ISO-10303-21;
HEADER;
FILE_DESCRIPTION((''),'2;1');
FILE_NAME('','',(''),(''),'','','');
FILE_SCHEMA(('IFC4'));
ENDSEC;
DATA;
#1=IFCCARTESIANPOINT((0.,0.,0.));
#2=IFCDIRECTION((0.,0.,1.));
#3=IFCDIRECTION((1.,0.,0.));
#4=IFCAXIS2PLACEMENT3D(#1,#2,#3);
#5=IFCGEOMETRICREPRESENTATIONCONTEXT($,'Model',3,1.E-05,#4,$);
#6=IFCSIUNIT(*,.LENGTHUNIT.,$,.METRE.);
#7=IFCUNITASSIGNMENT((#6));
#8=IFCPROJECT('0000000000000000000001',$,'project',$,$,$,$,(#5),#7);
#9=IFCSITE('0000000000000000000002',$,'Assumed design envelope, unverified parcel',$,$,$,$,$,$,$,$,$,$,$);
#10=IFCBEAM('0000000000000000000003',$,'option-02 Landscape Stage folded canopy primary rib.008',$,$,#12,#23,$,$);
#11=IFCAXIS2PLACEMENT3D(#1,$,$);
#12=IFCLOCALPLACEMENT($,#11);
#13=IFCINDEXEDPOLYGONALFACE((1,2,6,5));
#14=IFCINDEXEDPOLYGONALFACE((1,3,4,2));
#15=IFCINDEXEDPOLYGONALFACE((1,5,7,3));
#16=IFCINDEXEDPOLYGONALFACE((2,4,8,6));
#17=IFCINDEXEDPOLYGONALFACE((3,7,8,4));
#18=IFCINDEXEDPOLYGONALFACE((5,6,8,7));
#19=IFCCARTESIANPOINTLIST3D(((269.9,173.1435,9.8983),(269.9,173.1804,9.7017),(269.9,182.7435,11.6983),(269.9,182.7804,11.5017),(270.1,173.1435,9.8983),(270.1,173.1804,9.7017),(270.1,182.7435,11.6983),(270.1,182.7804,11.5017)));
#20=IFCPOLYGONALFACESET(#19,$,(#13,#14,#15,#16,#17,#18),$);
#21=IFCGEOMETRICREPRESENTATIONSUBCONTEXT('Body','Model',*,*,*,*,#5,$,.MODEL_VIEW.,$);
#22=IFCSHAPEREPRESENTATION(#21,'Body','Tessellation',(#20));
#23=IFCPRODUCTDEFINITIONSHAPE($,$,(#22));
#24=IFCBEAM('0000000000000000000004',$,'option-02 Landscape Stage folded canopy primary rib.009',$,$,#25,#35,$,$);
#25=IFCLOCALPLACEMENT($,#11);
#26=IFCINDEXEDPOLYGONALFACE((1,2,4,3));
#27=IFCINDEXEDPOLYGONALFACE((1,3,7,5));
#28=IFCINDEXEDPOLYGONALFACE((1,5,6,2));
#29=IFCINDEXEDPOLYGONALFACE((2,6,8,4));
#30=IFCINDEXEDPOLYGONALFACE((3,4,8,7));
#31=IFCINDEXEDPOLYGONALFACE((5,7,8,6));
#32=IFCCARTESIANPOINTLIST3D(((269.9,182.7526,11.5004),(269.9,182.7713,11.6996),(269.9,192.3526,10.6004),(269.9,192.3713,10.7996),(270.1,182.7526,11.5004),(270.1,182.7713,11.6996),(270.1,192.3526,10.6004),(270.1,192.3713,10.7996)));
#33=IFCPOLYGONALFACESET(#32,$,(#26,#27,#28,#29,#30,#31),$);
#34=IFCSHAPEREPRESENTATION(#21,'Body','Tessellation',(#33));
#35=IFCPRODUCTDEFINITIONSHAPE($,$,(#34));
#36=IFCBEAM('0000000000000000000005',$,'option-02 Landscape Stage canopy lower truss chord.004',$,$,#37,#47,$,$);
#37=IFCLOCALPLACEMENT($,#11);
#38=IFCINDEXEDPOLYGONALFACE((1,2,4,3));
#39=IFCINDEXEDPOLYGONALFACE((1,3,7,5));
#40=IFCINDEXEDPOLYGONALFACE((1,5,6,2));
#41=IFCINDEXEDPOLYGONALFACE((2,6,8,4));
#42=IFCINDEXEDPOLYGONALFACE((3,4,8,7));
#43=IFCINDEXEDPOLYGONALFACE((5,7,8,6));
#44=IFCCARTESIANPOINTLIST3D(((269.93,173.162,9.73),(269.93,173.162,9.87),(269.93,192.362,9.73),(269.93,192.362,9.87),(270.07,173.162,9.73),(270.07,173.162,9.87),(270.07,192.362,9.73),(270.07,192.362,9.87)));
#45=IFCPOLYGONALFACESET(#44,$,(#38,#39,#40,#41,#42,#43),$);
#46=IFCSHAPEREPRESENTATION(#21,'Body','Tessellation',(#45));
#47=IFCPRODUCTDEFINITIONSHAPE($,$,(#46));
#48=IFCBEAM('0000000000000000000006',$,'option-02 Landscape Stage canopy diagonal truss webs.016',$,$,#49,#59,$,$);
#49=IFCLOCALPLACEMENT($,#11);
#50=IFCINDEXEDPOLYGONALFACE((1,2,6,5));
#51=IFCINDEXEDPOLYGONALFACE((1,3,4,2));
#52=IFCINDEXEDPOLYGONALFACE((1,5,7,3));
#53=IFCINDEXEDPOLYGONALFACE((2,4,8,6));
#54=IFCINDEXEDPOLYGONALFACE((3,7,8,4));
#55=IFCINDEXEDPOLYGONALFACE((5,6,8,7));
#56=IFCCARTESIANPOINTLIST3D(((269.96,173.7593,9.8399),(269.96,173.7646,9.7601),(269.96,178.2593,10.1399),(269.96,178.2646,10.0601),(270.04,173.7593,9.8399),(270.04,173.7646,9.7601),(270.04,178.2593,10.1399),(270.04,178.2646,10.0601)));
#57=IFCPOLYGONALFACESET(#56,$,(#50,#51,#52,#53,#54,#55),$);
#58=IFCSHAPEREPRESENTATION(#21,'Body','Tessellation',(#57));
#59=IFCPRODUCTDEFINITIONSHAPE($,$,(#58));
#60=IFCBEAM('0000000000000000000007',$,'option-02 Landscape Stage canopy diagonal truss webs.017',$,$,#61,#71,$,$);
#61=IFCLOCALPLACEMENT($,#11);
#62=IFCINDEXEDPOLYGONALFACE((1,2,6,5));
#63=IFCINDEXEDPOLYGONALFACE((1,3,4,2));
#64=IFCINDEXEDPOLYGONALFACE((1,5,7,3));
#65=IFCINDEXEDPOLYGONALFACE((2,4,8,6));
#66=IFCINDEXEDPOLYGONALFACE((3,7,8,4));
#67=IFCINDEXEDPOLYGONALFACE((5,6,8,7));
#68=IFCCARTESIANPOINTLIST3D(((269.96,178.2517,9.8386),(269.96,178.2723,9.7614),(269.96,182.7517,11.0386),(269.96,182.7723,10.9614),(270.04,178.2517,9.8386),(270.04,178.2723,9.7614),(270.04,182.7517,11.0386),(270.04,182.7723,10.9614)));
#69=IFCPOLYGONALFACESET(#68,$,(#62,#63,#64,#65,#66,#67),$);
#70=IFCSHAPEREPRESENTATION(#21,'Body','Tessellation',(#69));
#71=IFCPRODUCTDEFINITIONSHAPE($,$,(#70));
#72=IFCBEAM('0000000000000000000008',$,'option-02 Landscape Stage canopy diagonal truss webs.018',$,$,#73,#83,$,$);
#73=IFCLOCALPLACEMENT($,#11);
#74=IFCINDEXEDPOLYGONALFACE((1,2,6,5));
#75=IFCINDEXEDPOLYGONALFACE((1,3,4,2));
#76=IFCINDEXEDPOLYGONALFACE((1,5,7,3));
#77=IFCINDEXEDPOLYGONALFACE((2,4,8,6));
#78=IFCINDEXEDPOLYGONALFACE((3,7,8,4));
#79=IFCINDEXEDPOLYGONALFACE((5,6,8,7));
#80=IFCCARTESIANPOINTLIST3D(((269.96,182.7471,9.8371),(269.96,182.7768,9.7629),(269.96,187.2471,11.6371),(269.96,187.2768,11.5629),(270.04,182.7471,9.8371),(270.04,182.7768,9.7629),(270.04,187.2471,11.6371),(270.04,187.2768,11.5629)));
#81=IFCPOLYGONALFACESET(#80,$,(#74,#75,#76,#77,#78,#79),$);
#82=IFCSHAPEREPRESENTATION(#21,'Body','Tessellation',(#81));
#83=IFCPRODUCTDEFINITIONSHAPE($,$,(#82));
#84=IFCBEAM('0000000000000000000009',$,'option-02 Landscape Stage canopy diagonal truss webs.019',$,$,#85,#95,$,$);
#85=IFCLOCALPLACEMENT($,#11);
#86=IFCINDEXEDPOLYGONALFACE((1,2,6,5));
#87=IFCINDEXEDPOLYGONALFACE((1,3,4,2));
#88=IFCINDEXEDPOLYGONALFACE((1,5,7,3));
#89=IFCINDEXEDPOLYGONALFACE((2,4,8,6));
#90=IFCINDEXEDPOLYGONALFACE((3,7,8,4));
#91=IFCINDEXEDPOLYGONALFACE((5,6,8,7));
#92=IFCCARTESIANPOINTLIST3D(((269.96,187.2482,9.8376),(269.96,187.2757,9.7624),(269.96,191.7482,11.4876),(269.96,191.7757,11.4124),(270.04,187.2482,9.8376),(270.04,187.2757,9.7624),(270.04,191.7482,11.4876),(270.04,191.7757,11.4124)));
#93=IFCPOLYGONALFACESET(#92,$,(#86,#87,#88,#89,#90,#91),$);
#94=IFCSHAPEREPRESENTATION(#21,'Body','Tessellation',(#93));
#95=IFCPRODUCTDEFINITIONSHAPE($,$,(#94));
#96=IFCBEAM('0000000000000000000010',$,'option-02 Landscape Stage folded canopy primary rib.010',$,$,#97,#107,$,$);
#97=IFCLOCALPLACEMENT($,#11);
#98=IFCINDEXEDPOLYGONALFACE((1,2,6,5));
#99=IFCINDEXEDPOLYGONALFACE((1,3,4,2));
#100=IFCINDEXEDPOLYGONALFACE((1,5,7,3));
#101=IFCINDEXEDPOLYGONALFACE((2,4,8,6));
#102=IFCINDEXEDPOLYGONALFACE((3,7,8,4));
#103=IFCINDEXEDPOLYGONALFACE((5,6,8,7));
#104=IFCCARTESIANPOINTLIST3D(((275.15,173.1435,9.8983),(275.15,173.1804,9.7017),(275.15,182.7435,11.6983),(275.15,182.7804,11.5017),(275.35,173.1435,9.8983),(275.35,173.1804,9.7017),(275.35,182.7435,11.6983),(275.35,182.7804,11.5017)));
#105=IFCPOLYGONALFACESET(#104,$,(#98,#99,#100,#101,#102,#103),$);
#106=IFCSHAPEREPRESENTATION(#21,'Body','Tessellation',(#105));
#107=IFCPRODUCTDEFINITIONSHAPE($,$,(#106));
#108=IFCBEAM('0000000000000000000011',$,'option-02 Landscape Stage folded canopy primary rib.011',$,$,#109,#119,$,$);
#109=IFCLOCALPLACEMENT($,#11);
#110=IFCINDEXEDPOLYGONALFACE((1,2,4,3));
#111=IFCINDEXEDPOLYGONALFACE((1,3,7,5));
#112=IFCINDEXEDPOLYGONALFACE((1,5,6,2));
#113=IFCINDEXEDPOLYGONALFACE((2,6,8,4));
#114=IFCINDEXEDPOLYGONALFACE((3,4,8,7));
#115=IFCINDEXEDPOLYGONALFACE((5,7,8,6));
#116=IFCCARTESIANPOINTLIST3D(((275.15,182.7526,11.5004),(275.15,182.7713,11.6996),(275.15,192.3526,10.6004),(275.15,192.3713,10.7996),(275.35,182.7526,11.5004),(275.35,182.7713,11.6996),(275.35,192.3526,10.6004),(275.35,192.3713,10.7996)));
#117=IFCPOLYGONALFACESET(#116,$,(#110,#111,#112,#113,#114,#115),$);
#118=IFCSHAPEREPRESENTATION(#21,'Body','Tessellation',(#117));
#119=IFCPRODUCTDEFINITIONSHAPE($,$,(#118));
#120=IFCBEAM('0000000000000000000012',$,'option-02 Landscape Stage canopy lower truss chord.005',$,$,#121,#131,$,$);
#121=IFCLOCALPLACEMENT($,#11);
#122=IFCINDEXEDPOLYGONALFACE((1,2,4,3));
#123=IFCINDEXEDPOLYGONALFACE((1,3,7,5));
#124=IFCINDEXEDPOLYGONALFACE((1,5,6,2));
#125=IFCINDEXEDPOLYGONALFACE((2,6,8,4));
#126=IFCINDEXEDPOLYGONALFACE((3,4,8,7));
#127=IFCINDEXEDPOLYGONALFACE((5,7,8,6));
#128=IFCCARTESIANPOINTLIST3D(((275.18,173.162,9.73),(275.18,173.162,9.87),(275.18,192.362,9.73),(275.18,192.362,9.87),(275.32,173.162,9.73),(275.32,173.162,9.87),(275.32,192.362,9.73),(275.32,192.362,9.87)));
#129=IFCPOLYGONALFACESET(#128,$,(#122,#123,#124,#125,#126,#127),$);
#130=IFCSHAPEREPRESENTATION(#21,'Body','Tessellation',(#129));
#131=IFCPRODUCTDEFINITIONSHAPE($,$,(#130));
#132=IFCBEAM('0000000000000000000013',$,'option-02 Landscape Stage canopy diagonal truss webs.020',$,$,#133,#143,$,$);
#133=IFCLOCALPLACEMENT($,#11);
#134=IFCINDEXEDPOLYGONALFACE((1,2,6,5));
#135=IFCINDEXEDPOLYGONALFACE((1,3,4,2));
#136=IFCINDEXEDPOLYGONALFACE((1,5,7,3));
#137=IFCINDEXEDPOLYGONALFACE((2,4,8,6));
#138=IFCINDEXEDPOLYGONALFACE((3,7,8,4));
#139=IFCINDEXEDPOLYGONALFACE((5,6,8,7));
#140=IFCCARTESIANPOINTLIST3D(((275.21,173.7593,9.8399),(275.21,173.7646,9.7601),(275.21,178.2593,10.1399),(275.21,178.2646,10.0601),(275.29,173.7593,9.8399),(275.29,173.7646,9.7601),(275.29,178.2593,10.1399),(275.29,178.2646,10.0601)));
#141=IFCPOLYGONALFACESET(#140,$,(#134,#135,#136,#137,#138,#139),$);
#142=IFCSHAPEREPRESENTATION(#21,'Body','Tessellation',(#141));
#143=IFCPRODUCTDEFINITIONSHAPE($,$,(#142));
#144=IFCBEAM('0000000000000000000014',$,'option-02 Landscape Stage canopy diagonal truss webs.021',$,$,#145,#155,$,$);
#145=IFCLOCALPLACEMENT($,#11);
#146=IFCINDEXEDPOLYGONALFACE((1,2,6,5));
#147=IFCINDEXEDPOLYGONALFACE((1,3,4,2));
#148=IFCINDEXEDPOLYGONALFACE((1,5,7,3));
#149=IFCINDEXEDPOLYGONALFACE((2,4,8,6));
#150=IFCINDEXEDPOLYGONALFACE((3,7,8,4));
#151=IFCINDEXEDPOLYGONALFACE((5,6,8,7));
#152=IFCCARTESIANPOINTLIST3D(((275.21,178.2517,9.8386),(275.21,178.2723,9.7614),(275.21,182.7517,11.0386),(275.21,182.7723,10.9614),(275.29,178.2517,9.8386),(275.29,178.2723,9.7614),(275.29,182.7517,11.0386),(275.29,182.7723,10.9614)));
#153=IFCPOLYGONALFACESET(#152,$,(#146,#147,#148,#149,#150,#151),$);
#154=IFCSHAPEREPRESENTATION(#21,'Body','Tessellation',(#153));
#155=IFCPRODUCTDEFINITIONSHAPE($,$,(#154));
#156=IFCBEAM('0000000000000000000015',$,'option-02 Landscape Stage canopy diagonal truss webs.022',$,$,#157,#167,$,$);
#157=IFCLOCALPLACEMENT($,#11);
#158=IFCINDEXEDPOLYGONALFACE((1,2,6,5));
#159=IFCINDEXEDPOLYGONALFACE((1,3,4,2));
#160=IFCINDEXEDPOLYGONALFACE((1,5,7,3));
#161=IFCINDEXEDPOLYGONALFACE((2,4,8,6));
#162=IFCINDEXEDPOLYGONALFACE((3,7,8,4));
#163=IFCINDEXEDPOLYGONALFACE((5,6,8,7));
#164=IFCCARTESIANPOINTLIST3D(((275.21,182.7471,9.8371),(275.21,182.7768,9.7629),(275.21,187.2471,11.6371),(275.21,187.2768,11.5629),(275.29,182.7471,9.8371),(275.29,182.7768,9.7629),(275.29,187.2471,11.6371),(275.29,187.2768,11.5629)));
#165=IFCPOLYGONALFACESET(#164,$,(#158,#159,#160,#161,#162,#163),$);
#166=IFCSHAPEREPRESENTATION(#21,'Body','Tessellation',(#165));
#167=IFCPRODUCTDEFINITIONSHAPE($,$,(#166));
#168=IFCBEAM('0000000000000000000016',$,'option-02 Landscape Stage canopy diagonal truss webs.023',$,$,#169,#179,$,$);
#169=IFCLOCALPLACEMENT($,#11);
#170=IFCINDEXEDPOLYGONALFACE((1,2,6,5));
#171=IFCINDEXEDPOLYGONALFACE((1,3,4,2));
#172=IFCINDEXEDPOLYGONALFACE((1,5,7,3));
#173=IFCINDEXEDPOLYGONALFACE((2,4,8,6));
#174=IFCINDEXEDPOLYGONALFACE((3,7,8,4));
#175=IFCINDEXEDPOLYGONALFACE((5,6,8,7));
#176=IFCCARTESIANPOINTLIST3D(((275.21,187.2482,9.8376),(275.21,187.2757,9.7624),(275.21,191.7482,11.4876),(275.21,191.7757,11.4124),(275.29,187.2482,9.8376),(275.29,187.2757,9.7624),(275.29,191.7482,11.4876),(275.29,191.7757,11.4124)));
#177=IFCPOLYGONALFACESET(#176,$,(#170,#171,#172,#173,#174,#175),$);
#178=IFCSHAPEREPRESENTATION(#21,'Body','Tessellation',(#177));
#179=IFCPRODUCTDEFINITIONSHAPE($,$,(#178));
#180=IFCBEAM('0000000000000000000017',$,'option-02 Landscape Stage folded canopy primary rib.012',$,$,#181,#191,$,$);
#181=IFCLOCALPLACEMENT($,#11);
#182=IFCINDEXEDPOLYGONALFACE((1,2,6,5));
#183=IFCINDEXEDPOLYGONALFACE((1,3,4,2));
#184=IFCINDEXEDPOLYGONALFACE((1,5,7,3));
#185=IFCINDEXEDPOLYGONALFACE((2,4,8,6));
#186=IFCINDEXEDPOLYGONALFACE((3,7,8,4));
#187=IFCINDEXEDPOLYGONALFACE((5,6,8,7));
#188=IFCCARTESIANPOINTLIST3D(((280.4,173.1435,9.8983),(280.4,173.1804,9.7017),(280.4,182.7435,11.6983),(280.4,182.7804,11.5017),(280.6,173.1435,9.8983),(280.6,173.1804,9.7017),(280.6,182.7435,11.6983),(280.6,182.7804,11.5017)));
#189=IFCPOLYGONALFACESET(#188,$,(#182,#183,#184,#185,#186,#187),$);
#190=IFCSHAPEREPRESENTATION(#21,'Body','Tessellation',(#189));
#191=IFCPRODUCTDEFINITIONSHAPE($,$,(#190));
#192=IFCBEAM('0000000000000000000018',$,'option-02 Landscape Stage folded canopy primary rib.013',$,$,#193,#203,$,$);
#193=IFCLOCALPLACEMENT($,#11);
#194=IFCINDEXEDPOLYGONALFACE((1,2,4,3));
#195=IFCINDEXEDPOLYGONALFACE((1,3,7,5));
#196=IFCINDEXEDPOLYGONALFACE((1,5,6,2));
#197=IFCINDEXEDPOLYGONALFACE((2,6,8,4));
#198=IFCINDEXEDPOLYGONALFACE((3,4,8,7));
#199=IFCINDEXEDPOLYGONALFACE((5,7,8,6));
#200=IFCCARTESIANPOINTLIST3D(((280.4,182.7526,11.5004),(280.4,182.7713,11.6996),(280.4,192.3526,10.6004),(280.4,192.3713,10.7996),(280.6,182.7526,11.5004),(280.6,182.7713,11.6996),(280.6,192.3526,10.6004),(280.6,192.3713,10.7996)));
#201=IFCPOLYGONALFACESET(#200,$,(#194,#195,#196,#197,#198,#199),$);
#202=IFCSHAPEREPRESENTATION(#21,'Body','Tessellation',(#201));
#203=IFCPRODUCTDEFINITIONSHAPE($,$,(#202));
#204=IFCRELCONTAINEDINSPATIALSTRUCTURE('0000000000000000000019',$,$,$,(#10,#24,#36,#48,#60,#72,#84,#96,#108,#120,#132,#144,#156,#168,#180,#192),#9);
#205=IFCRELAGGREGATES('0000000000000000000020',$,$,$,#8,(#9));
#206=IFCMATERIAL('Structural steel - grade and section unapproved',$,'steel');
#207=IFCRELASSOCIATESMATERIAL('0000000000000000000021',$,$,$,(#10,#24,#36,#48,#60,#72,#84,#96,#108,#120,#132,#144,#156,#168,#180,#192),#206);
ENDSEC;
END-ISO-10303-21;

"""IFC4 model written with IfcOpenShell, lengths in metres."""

from ifc_helpers import new_model, si_unit, frame, origin_with_axes, place, context, subcontext, project, spatial, rectangle, extrude, material, element, save


model = new_model("IFC4")

# Units and contexts
model_context = context("Model", 3, precision=1e-05, world=origin_with_axes())
body_context = subcontext(model_context, "Body", "Model", "MODEL_VIEW")
ifc_project = project(units=[si_unit("LENGTHUNIT", "METRE")], contexts=[model_context])

# Site
site = spatial("IfcSite", under=ifc_project, Name="Assumed design envelope, unverified parcel")

# Beams
ifc_material_1 = material(Name="Structural steel - grade and section unapproved", Category="steel")
beam_1_placement = place(None, frame((270.0, 173.162, 9.8), z_axis=(0.0, 0.982872, 0.184289), x_axis=(-1.0, 0.0, 0.0)))
element("IfcBeam", 1, at=beam_1_placement, inside=site, material=ifc_material_1, Name="option-02 Landscape Stage folded canopy primary rib.008", context=body_context, shape_type="SweptSolid", body=[
    extrude(rectangle(XDim=0.2, YDim=0.2), origin_with_axes(), (0.0, 0.0, 1.0), 9.7673),
])
beam_2_placement = place(None, frame((270.0, 182.762, 11.6), z_axis=(0.0, 0.995634, -0.093341), x_axis=(-1.0, 0.0, 0.0)))
element("IfcBeam", 2, at=beam_2_placement, inside=site, material=ifc_material_1, Name="option-02 Landscape Stage folded canopy primary rib.009", context=body_context, shape_type="SweptSolid", body=[
    extrude(rectangle(XDim=0.2, YDim=0.2), origin_with_axes(), (0.0, 0.0, 1.0), 9.6421),
])
beam_3_placement = place(None, frame((270.0, 173.162, 9.8), z_axis=(0.0, 1.0, 0.0), x_axis=(-1.0, 0.0, 0.0)))
element("IfcBeam", 3, at=beam_3_placement, inside=site, material=ifc_material_1, Name="option-02 Landscape Stage canopy lower truss chord.004", context=body_context, shape_type="SweptSolid", body=[
    extrude(rectangle(XDim=0.14, YDim=0.14), origin_with_axes(), (0.0, 0.0, 1.0), 19.2),
])
beam_4_placement = place(None, frame((270.0, 173.762, 9.8), z_axis=(0.0, 0.997785, 0.066519), x_axis=(-1.0, 0.0, 0.0)))
element("IfcBeam", 4, at=beam_4_placement, inside=site, material=ifc_material_1, Name="option-02 Landscape Stage canopy diagonal truss webs.016", context=body_context, shape_type="SweptSolid", body=[
    extrude(rectangle(XDim=0.08, YDim=0.08), origin_with_axes(), (0.0, 0.0, 1.0), 4.51),
])
beam_5_placement = place(None, frame((270.0, 178.262, 9.8), z_axis=(0.0, 0.966235, 0.257663), x_axis=(-1.0, 0.0, 0.0)))
element("IfcBeam", 5, at=beam_5_placement, inside=site, material=ifc_material_1, Name="option-02 Landscape Stage canopy diagonal truss webs.017", context=body_context, shape_type="SweptSolid", body=[
    extrude(rectangle(XDim=0.08, YDim=0.08), origin_with_axes(), (0.0, 0.0, 1.0), 4.6573),
])
beam_6_placement = place(None, frame((270.0, 182.762, 9.8), z_axis=(0.0, 0.928477, 0.371391), x_axis=(-1.0, 0.0, 0.0)))
element("IfcBeam", 6, at=beam_6_placement, inside=site, material=ifc_material_1, Name="option-02 Landscape Stage canopy diagonal truss webs.018", context=body_context, shape_type="SweptSolid", body=[
    extrude(rectangle(XDim=0.08, YDim=0.08), origin_with_axes(), (0.0, 0.0, 1.0), 4.8466),
])
beam_7_placement = place(None, frame((270.0, 187.262, 9.8), z_axis=(0.0, 0.938876, 0.344255), x_axis=(-1.0, 0.0, 0.0)))
element("IfcBeam", 7, at=beam_7_placement, inside=site, material=ifc_material_1, Name="option-02 Landscape Stage canopy diagonal truss webs.019", context=body_context, shape_type="SweptSolid", body=[
    extrude(rectangle(XDim=0.08, YDim=0.08), origin_with_axes(), (0.0, 0.0, 1.0), 4.793),
])
beam_8_placement = place(None, frame((275.25, 173.162, 9.8), z_axis=(0.0, 0.982872, 0.184289), x_axis=(-1.0, 0.0, 0.0)))
element("IfcBeam", 8, at=beam_8_placement, inside=site, material=ifc_material_1, Name="option-02 Landscape Stage folded canopy primary rib.010", context=body_context, shape_type="SweptSolid", body=[
    extrude(rectangle(XDim=0.2, YDim=0.2), origin_with_axes(), (0.0, 0.0, 1.0), 9.7673),
])
beam_9_placement = place(None, frame((275.25, 182.762, 11.6), z_axis=(0.0, 0.995634, -0.093341), x_axis=(-1.0, 0.0, 0.0)))
element("IfcBeam", 9, at=beam_9_placement, inside=site, material=ifc_material_1, Name="option-02 Landscape Stage folded canopy primary rib.011", context=body_context, shape_type="SweptSolid", body=[
    extrude(rectangle(XDim=0.2, YDim=0.2), origin_with_axes(), (0.0, 0.0, 1.0), 9.6421),
])
beam_10_placement = place(None, frame((275.25, 173.162, 9.8), z_axis=(0.0, 1.0, 0.0), x_axis=(-1.0, 0.0, 0.0)))
element("IfcBeam", 10, at=beam_10_placement, inside=site, material=ifc_material_1, Name="option-02 Landscape Stage canopy lower truss chord.005", context=body_context, shape_type="SweptSolid", body=[
    extrude(rectangle(XDim=0.14, YDim=0.14), origin_with_axes(), (0.0, 0.0, 1.0), 19.2),
])
beam_11_placement = place(None, frame((275.25, 173.762, 9.8), z_axis=(0.0, 0.997785, 0.066519), x_axis=(-1.0, 0.0, 0.0)))
element("IfcBeam", 11, at=beam_11_placement, inside=site, material=ifc_material_1, Name="option-02 Landscape Stage canopy diagonal truss webs.020", context=body_context, shape_type="SweptSolid", body=[
    extrude(rectangle(XDim=0.08, YDim=0.08), origin_with_axes(), (0.0, 0.0, 1.0), 4.51),
])
beam_12_placement = place(None, frame((275.25, 178.262, 9.8), z_axis=(0.0, 0.966235, 0.257663), x_axis=(-1.0, 0.0, 0.0)))
element("IfcBeam", 12, at=beam_12_placement, inside=site, material=ifc_material_1, Name="option-02 Landscape Stage canopy diagonal truss webs.021", context=body_context, shape_type="SweptSolid", body=[
    extrude(rectangle(XDim=0.08, YDim=0.08), origin_with_axes(), (0.0, 0.0, 1.0), 4.6573),
])
beam_13_placement = place(None, frame((275.25, 182.762, 9.8), z_axis=(0.0, 0.928477, 0.371391), x_axis=(-1.0, 0.0, 0.0)))
element("IfcBeam", 13, at=beam_13_placement, inside=site, material=ifc_material_1, Name="option-02 Landscape Stage canopy diagonal truss webs.022", context=body_context, shape_type="SweptSolid", body=[
    extrude(rectangle(XDim=0.08, YDim=0.08), origin_with_axes(), (0.0, 0.0, 1.0), 4.8466),
])
beam_14_placement = place(None, frame((275.25, 187.262, 9.8), z_axis=(0.0, 0.938876, 0.344255), x_axis=(-1.0, 0.0, 0.0)))
element("IfcBeam", 14, at=beam_14_placement, inside=site, material=ifc_material_1, Name="option-02 Landscape Stage canopy diagonal truss webs.023", context=body_context, shape_type="SweptSolid", body=[
    extrude(rectangle(XDim=0.08, YDim=0.08), origin_with_axes(), (0.0, 0.0, 1.0), 4.793),
])
beam_15_placement = place(None, frame((280.5, 173.162, 9.8), z_axis=(0.0, 0.982872, 0.184289), x_axis=(-1.0, 0.0, 0.0)))
element("IfcBeam", 15, at=beam_15_placement, inside=site, material=ifc_material_1, Name="option-02 Landscape Stage folded canopy primary rib.012", context=body_context, shape_type="SweptSolid", body=[
    extrude(rectangle(XDim=0.2, YDim=0.2), origin_with_axes(), (0.0, 0.0, 1.0), 9.7673),
])
beam_16_placement = place(None, frame((280.5, 182.762, 11.6), z_axis=(0.0, 0.995634, -0.093341), x_axis=(-1.0, 0.0, 0.0)))
element("IfcBeam", 16, at=beam_16_placement, inside=site, material=ifc_material_1, Name="option-02 Landscape Stage folded canopy primary rib.013", context=body_context, shape_type="SweptSolid", body=[
    extrude(rectangle(XDim=0.2, YDim=0.2), origin_with_axes(), (0.0, 0.0, 1.0), 9.6421),
])

save(model, "model.ifc")
